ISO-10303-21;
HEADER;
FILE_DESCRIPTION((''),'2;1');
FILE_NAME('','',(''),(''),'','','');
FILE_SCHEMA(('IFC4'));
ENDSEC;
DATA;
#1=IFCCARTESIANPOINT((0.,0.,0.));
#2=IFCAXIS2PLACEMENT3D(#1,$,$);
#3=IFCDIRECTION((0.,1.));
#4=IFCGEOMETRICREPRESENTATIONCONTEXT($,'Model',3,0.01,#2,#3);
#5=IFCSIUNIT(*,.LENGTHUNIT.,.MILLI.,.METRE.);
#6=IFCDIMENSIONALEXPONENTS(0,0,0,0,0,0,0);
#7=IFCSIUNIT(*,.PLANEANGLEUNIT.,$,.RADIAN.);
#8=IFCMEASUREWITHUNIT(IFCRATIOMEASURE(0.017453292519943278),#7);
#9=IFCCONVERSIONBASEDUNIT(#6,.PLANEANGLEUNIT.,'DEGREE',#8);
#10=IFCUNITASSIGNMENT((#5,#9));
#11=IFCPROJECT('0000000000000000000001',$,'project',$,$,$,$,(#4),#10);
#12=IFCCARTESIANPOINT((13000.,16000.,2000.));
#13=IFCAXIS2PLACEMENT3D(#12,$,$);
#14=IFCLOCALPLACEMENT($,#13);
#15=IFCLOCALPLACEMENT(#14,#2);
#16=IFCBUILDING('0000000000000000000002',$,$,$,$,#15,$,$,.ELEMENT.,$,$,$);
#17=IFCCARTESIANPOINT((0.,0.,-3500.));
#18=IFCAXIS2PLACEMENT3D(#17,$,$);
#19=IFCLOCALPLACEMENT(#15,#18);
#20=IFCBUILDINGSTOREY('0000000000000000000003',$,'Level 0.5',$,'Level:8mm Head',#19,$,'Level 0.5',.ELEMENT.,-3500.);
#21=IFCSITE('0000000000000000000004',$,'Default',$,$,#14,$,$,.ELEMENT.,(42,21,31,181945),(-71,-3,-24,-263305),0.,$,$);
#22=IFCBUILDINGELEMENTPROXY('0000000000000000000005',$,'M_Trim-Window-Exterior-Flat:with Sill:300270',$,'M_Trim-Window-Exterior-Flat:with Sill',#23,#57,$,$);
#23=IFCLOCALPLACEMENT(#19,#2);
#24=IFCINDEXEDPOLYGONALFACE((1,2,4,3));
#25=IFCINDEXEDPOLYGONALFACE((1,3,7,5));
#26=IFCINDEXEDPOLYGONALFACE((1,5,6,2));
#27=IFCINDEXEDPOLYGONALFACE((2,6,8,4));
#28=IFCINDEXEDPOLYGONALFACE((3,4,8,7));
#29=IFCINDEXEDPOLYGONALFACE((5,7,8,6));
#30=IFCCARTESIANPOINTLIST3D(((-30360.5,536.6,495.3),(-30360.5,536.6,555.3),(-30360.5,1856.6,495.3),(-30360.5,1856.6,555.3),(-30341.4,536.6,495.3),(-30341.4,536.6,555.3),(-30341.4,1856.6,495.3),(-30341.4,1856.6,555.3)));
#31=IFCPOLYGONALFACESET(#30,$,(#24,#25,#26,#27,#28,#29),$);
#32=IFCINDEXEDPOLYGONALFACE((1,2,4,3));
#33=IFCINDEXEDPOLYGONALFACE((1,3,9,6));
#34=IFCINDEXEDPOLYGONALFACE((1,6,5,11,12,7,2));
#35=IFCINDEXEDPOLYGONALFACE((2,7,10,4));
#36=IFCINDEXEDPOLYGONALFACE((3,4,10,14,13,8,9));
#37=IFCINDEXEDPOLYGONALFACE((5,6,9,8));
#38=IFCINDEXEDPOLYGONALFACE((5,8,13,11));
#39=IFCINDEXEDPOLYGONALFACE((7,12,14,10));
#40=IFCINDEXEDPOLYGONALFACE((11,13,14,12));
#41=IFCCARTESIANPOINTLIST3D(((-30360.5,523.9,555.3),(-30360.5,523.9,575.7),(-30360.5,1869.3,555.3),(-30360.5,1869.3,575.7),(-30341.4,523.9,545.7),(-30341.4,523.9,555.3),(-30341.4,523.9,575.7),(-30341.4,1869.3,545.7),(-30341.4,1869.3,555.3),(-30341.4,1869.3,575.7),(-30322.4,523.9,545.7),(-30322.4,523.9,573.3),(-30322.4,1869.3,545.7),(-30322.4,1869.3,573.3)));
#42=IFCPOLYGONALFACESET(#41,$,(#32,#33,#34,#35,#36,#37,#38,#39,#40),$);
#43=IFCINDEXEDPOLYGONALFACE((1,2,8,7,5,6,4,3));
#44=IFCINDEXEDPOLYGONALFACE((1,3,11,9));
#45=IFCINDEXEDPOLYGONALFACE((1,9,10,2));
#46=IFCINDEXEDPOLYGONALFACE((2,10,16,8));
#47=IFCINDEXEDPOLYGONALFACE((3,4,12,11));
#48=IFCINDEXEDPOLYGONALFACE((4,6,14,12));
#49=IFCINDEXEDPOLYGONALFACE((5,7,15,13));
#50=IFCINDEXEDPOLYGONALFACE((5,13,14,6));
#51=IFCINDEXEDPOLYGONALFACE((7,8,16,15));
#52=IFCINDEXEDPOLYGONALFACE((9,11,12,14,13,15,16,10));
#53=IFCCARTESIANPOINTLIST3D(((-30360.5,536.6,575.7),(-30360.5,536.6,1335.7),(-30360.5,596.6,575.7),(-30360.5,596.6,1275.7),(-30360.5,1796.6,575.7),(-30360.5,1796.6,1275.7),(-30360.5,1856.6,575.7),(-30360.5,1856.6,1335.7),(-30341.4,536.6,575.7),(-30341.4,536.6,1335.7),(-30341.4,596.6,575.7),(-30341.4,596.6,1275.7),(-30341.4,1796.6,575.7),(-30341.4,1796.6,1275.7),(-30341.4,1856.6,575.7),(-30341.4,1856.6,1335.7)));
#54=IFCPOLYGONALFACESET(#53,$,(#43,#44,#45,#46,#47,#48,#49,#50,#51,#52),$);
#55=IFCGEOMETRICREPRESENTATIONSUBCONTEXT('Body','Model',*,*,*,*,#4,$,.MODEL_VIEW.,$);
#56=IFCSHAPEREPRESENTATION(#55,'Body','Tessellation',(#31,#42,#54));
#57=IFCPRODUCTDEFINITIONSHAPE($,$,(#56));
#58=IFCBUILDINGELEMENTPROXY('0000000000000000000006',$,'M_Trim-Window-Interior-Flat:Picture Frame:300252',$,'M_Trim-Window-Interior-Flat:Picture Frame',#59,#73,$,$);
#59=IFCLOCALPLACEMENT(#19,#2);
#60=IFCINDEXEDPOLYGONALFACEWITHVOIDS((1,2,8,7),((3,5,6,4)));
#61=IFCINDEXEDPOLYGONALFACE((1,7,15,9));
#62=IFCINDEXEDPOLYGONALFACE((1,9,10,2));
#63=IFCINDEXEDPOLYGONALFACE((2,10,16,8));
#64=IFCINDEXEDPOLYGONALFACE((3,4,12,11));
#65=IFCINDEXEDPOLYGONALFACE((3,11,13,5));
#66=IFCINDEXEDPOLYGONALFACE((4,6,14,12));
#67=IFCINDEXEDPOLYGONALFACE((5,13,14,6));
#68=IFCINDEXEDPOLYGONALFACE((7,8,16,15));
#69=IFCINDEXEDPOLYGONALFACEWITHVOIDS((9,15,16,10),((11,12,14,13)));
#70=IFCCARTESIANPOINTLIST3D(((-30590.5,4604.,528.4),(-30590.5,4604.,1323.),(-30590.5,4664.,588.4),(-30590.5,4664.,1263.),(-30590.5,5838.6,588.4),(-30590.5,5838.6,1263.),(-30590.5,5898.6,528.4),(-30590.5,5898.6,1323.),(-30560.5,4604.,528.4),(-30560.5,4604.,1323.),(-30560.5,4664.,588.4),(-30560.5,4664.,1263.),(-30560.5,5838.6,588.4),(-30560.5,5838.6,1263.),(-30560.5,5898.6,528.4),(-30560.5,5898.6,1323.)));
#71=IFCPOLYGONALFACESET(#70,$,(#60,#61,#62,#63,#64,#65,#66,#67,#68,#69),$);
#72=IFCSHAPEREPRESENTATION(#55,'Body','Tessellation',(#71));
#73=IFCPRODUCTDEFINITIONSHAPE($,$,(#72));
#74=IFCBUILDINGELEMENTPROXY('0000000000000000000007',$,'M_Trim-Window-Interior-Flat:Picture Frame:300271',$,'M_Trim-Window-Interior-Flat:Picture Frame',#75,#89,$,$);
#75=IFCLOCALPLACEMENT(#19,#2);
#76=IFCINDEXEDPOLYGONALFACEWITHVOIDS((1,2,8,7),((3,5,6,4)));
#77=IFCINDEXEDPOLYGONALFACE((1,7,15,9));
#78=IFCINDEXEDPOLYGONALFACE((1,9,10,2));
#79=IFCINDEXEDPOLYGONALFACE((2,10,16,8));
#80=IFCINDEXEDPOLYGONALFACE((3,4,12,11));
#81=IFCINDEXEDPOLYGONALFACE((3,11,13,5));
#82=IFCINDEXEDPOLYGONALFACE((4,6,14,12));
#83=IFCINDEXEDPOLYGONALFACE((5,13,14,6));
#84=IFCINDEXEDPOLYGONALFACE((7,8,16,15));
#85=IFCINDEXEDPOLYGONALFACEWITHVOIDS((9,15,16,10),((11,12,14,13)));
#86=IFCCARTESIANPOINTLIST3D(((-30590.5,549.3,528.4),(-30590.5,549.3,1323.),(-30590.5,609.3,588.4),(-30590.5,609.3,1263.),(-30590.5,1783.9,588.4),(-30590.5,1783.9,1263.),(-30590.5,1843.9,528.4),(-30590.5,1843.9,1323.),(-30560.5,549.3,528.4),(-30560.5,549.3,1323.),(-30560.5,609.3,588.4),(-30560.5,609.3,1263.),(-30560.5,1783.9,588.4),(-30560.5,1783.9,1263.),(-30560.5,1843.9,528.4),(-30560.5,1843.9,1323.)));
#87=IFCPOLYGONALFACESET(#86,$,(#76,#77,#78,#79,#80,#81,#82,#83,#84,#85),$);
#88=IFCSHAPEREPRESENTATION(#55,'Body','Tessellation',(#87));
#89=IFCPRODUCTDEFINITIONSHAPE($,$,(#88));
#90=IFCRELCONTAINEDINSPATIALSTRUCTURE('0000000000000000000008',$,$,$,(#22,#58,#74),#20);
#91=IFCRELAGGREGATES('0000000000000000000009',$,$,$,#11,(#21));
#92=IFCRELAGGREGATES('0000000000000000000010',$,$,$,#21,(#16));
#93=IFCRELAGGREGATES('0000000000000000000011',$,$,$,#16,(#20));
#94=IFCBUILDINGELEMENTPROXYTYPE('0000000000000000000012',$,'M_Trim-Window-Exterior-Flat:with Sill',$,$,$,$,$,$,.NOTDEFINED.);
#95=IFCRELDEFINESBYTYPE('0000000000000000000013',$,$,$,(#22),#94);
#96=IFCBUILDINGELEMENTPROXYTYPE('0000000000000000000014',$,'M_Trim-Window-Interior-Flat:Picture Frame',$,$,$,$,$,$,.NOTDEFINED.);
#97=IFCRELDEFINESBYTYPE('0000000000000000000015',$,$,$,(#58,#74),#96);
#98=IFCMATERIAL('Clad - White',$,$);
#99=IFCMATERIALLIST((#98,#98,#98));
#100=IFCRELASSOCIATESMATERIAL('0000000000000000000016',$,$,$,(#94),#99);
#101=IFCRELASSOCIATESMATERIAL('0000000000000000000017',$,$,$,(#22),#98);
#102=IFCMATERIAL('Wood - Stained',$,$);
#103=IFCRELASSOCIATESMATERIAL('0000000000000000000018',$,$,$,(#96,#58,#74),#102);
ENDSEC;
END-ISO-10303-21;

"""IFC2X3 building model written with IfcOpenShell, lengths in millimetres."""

from ifc_helpers import new_model, entity, si_unit, converted_unit, direction, frame, frame_2d, origin, place, context, subcontext, project, spatial, polyline, rectangle, outline, extrude, source, transform, mapped, material, material_list, type_object, type_shapes, element, save


model = new_model("IFC2X3")

# Units and contexts
model_context = context("Model", 3, precision=0.01, world=origin(), true_north=direction((0.0, 1.0)))
body_context = subcontext(model_context, "Body", "Model", "MODEL_VIEW")
ifc_project = project(units=[si_unit("LENGTHUNIT", "METRE", prefix="MILLI"), converted_unit("PLANEANGLEUNIT", "DEGREE", entity("IfcRatioMeasure", 0.017453292519943278), si_unit("PLANEANGLEUNIT", "RADIAN"), dimensions=[0, 0, 0, 0, 0, 0, 0])], contexts=[model_context])

# Site, building, storey
site_placement = place(None, frame((13000.0, 16000.0, 2000.0)))
site = spatial("IfcSite", under=ifc_project, at=site_placement, Name="Default", CompositionType="ELEMENT", RefLatitude=(42, 21, 31, 181945), RefLongitude=(-71, -3, -24, -263305), RefElevation=0.0)
building_placement = place(site_placement, origin())
building = spatial("IfcBuilding", under=site, at=building_placement, CompositionType="ELEMENT")
storey_placement = place(building_placement, frame((0.0, 0.0, -3500.0)))
storey = spatial("IfcBuildingStorey", under=building, at=storey_placement, Name="Level 0.5", ObjectType="Level:8mm Head", LongName="Level 0.5", CompositionType="ELEMENT", Elevation=-3500.0)

# Building element proxies
ifc_material_1 = material(Name="Clad - White")
ifc_material_2 = material(Name="Wood - Stained")
ifc_material_list_1 = material_list([ifc_material_1, ifc_material_1, ifc_material_1])
building_element_proxy_type_1 = type_object("IfcBuildingElementProxyType", Name="M_Trim-Window-Exterior-Flat:with Sill", PredefinedType="NOTDEFINED", material=ifc_material_list_1)
shared_shape_1 = source(origin(), body_context, "Body", "SweptSolid", [
    extrude(rectangle(XDim=1320.0, YDim=60.0, at=frame_2d((0.0, 0.0), x_axis=(1.0, 0.0))), frame((0.0, -750.4, 0.0), z_axis=(0.0, 0.0, 1.0), x_axis=(-1.0, 0.0, 0.0)), (0.0, 0.0, 1.0), 19.0),
    extrude(outline(polyline([(-19.0, -15.2), (0.0, -15.2), (0.0, -5.7), (19.0, -5.7), (19.0, 14.8), (0.0, 14.8), (-19.0, 12.3), (-19.0, -15.2)])), frame((-672.7, -714.8, 19.0), z_axis=(1.0, 0.0, 0.0), x_axis=(0.0, 0.0, -1.0)), (0.0, 0.0, 1.0), 1345.4),
    extrude(outline(polyline([(-395.0, -660.0), (365.0, -660.0), (365.0, -600.0), (-335.0, -600.0), (-335.0, 600.0), (365.0, 600.0), (365.0, 660.0), (-395.0, 660.0), (-395.0, -660.0)])), frame((0.0, -335.0, 0.0), z_axis=(0.0, 0.0, 1.0), x_axis=(0.0, -1.0, 0.0)), (0.0, 0.0, 1.0), 19.0),
])
type_shapes(building_element_proxy_type_1, [shared_shape_1])
for number, where, z_axis, x_axis, name in (
    (1, (-30360.5, 1196.6, 1275.7), (1.0, 0.0, 0.0), (0.0, 1.0, 0.0), "M_Trim-Window-Exterior-Flat:with Sill:300270"),
):
    element("IfcBuildingElementProxy", number, at=place(storey_placement, frame(where, z_axis=z_axis, x_axis=x_axis)), inside=storey, type_object=building_element_proxy_type_1, material=ifc_material_1, Name=name, ObjectType="M_Trim-Window-Exterior-Flat:with Sill", context=body_context, shape_type="MappedRepresentation", body=[
        mapped(shared_shape_1, transform((0.0, 0.0, 0.0), scale=1.0)),
    ])
building_element_proxy_type_2 = type_object("IfcBuildingElementProxyType", Name="M_Trim-Window-Interior-Flat:Picture Frame", PredefinedType="NOTDEFINED", material=ifc_material_2)
shared_shape_2 = source(origin(), body_context, "Body", "SweptSolid", [
    extrude(outline(polyline([(-647.3, -397.3), (647.3, -397.3), (647.3, 397.3), (-647.3, 397.3), (-647.3, -397.3)]), holes=[polyline([(-587.3, -337.3), (-587.3, 337.3), (587.3, 337.3), (587.3, -337.3), (-587.3, -337.3)])]), frame((0.0, -350.0, 0.0), z_axis=(0.0, 0.0, 1.0), x_axis=(-1.0, 0.0, 0.0)), (0.0, 0.0, 1.0), 30.0),
])
type_shapes(building_element_proxy_type_2, [shared_shape_2])
for number, where, z_axis, x_axis, name in (
    (2, (-30560.5, 5251.3, 1275.7), (-1.0, 0.0, 0.0), (0.0, -1.0, 0.0), "M_Trim-Window-Interior-Flat:Picture Frame:300252"),
    (3, (-30560.5, 1196.6, 1275.7), (-1.0, 0.0, 0.0), (0.0, -1.0, 0.0), "M_Trim-Window-Interior-Flat:Picture Frame:300271"),
):
    element("IfcBuildingElementProxy", number, at=place(storey_placement, frame(where, z_axis=z_axis, x_axis=x_axis)), inside=storey, type_object=building_element_proxy_type_2, material=ifc_material_2, Name=name, ObjectType="M_Trim-Window-Interior-Flat:Picture Frame", context=body_context, shape_type="MappedRepresentation", body=[
        mapped(shared_shape_2, transform((0.0, 0.0, 0.0), scale=1.0)),
    ])

save(model, "model.ifc")
